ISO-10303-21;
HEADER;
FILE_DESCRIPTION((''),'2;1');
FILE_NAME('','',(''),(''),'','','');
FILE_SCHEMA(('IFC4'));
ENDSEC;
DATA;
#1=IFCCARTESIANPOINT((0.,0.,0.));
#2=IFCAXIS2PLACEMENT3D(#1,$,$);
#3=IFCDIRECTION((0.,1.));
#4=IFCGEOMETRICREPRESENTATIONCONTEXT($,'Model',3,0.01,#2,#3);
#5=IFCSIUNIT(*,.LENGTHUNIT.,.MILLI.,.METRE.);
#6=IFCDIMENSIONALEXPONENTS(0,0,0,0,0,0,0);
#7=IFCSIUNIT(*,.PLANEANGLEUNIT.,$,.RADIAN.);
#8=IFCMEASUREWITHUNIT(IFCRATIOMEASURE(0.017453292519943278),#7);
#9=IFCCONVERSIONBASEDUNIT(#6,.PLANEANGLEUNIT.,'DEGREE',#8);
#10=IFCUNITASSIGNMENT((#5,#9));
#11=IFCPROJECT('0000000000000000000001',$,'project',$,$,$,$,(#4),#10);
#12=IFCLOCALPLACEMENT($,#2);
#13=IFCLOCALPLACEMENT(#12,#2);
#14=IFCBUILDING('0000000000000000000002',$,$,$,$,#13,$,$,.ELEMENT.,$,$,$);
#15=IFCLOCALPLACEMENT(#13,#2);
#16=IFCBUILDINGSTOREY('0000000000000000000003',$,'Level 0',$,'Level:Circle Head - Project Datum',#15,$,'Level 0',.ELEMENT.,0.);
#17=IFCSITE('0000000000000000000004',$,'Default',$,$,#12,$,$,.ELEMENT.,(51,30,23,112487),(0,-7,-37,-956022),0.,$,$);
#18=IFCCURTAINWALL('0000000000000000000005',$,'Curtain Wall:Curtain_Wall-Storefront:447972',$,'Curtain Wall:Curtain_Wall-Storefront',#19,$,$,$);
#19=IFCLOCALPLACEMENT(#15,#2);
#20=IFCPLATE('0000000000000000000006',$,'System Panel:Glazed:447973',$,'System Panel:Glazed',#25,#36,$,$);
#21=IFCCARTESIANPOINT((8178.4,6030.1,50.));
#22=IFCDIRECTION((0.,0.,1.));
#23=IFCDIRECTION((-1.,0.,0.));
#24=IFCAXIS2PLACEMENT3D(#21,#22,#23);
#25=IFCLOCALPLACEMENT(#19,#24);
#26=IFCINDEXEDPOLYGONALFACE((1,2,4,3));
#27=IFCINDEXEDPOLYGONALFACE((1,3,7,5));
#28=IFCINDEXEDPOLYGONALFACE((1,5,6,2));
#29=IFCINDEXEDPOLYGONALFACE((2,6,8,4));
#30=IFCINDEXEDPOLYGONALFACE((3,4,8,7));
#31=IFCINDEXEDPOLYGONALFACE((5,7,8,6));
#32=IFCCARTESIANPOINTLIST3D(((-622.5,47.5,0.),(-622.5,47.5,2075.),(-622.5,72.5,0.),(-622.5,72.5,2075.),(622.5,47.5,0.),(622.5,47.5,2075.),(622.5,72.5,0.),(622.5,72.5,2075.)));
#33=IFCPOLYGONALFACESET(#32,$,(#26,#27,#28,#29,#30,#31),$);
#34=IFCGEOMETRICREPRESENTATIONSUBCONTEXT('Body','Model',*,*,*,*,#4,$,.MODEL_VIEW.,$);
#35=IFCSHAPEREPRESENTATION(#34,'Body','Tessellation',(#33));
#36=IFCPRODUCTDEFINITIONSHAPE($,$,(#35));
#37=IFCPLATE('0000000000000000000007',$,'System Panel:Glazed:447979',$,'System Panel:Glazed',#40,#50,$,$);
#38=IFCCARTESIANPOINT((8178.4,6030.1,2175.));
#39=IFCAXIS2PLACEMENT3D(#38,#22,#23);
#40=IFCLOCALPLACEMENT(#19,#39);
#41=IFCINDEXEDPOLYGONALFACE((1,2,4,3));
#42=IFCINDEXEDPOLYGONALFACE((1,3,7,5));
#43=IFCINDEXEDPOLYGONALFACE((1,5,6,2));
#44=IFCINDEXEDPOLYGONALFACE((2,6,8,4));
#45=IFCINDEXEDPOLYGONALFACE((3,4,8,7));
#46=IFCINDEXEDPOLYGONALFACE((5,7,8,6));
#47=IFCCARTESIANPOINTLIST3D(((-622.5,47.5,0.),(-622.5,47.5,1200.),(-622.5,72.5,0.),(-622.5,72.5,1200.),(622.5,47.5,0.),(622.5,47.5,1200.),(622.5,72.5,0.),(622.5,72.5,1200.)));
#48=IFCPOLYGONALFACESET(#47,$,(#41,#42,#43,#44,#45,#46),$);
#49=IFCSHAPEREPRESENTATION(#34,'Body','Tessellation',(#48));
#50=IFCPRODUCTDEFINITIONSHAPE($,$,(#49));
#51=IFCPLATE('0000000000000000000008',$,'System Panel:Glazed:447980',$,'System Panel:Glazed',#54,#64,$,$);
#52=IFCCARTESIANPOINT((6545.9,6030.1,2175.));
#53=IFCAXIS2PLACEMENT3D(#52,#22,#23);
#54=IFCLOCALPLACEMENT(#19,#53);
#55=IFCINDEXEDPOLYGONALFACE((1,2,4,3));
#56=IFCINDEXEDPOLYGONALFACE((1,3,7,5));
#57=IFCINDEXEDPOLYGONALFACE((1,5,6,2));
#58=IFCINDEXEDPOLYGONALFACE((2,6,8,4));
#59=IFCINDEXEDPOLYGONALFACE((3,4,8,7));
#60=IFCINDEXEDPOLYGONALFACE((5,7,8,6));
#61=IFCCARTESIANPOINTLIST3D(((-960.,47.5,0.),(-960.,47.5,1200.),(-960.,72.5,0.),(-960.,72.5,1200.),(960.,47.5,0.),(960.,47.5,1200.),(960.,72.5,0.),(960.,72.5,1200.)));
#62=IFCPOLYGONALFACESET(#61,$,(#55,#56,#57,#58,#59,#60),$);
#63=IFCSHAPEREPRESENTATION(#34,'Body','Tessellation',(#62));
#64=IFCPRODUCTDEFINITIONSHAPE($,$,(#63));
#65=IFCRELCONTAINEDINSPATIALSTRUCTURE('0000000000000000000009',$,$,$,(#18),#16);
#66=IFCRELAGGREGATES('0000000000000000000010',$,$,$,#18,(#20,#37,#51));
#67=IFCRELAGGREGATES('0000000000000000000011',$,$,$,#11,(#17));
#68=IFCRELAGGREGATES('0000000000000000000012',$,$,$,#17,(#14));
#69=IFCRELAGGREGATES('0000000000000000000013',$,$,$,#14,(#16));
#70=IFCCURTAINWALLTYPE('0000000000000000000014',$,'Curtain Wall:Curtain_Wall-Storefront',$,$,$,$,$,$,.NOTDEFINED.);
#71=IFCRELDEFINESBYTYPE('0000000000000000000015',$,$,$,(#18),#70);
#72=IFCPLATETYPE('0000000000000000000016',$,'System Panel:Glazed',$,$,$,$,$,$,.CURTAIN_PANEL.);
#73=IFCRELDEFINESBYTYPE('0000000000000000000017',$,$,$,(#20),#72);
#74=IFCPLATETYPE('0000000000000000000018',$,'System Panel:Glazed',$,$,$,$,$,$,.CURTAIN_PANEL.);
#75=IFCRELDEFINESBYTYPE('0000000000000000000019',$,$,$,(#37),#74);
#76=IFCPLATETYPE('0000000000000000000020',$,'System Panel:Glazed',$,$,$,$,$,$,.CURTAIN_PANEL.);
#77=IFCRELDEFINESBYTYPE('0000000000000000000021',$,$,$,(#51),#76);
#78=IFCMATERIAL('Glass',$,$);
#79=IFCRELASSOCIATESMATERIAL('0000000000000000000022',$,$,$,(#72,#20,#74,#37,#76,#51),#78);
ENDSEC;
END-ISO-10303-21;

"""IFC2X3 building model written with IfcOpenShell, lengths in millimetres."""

from ifc_helpers import new_model, entity, si_unit, converted_unit, direction, frame, origin, origin_2d_with_axis, place, context, subcontext, project, spatial, rectangle, extrude, source, transform, mapped, material, type_object, type_shapes, element, aggregate, save


model = new_model("IFC2X3")

# Units and contexts
model_context = context("Model", 3, precision=0.01, world=origin(), true_north=direction((0.0, 1.0)))
body_context = subcontext(model_context, "Body", "Model", "MODEL_VIEW")
ifc_project = project(units=[si_unit("LENGTHUNIT", "METRE", prefix="MILLI"), converted_unit("PLANEANGLEUNIT", "DEGREE", entity("IfcRatioMeasure", 0.017453292519943278), si_unit("PLANEANGLEUNIT", "RADIAN"), dimensions=[0, 0, 0, 0, 0, 0, 0])], contexts=[model_context])

# Site, building, storey
site_placement = place(None, origin())
site = spatial("IfcSite", under=ifc_project, at=site_placement, Name="Default", CompositionType="ELEMENT", RefLatitude=(51, 30, 23, 112487), RefLongitude=(0, -7, -37, -956022), RefElevation=0.0)
building_placement = place(site_placement, origin())
building = spatial("IfcBuilding", under=site, at=building_placement, CompositionType="ELEMENT")
storey_placement = place(building_placement, origin())
storey = spatial("IfcBuildingStorey", under=building, at=storey_placement, Name="Level 0", ObjectType="Level:Circle Head - Project Datum", LongName="Level 0", CompositionType="ELEMENT", Elevation=0.0)

# Curtain wall
curtain_wall_type = type_object("IfcCurtainWallType", Name="Curtain Wall:Curtain_Wall-Storefront", PredefinedType="NOTDEFINED")
curtain_wall_1_placement = place(storey_placement, origin())
curtain_wall_1 = element("IfcCurtainWall", 1, at=curtain_wall_1_placement, inside=storey, type_object=curtain_wall_type, Name="Curtain Wall:Curtain_Wall-Storefront:447972", ObjectType="Curtain Wall:Curtain_Wall-Storefront")

# Plates
ifc_material_1 = material(Name="Glass")
plate_type_1 = type_object("IfcPlateType", Name="System Panel:Glazed", PredefinedType="CURTAIN_PANEL", material=ifc_material_1)
shared_shape_1 = source(origin(), body_context, "Body", "SweptSolid", [
    extrude(rectangle(XDim=25.0, YDim=1245.0, at=origin_2d_with_axis()), frame((0.0, 60.0, 0.0), z_axis=(0.0, 0.0, 1.0), x_axis=(0.0, 1.0, 0.0)), (0.0, 0.0, 1.0), 2075.0),
])
type_shapes(plate_type_1, [shared_shape_1])
plate_1_placement = place(curtain_wall_1_placement, frame((8178.4, 6030.1, 50.0), z_axis=(0.0, 0.0, 1.0), x_axis=(-1.0, 0.0, 0.0)))
plate_1 = element("IfcPlate", 2, at=plate_1_placement, type_object=plate_type_1, material=ifc_material_1, Name="System Panel:Glazed:447973", ObjectType="System Panel:Glazed", context=body_context, shape_type="MappedRepresentation", body=[
    mapped(shared_shape_1, transform((0.0, 0.0, 0.0), scale=1.0)),
])
plate_type_2 = type_object("IfcPlateType", Name="System Panel:Glazed", PredefinedType="CURTAIN_PANEL", material=ifc_material_1)
shared_shape_2 = source(origin(), body_context, "Body", "SweptSolid", [
    extrude(rectangle(XDim=25.0, YDim=1245.0, at=origin_2d_with_axis()), frame((0.0, 60.0, 0.0), z_axis=(0.0, 0.0, 1.0), x_axis=(0.0, 1.0, 0.0)), (0.0, 0.0, 1.0), 1200.0),
])
type_shapes(plate_type_2, [shared_shape_2])
plate_2_placement = place(curtain_wall_1_placement, frame((8178.4, 6030.1, 2175.0), z_axis=(0.0, 0.0, 1.0), x_axis=(-1.0, 0.0, 0.0)))
plate_2 = element("IfcPlate", 3, at=plate_2_placement, type_object=plate_type_2, material=ifc_material_1, Name="System Panel:Glazed:447979", ObjectType="System Panel:Glazed", context=body_context, shape_type="MappedRepresentation", body=[
    mapped(shared_shape_2, transform((0.0, 0.0, 0.0), scale=1.0)),
])
plate_type_3 = type_object("IfcPlateType", Name="System Panel:Glazed", PredefinedType="CURTAIN_PANEL", material=ifc_material_1)
shared_shape_3 = source(origin(), body_context, "Body", "SweptSolid", [
    extrude(rectangle(XDim=25.0, YDim=1920.0, at=origin_2d_with_axis()), frame((0.0, 60.0, 0.0), z_axis=(0.0, 0.0, 1.0), x_axis=(0.0, 1.0, 0.0)), (0.0, 0.0, 1.0), 1200.0),
])
type_shapes(plate_type_3, [shared_shape_3])
plate_3_placement = place(curtain_wall_1_placement, frame((6545.9, 6030.1, 2175.0), z_axis=(0.0, 0.0, 1.0), x_axis=(-1.0, 0.0, 0.0)))
plate_3 = element("IfcPlate", 4, at=plate_3_placement, type_object=plate_type_3, material=ifc_material_1, Name="System Panel:Glazed:447980", ObjectType="System Panel:Glazed", context=body_context, shape_type="MappedRepresentation", body=[
    mapped(shared_shape_3, transform((0.0, 0.0, 0.0), scale=1.0)),
])
aggregate(curtain_wall_1, [plate_1, plate_2, plate_3])

save(model, "model.ifc")
